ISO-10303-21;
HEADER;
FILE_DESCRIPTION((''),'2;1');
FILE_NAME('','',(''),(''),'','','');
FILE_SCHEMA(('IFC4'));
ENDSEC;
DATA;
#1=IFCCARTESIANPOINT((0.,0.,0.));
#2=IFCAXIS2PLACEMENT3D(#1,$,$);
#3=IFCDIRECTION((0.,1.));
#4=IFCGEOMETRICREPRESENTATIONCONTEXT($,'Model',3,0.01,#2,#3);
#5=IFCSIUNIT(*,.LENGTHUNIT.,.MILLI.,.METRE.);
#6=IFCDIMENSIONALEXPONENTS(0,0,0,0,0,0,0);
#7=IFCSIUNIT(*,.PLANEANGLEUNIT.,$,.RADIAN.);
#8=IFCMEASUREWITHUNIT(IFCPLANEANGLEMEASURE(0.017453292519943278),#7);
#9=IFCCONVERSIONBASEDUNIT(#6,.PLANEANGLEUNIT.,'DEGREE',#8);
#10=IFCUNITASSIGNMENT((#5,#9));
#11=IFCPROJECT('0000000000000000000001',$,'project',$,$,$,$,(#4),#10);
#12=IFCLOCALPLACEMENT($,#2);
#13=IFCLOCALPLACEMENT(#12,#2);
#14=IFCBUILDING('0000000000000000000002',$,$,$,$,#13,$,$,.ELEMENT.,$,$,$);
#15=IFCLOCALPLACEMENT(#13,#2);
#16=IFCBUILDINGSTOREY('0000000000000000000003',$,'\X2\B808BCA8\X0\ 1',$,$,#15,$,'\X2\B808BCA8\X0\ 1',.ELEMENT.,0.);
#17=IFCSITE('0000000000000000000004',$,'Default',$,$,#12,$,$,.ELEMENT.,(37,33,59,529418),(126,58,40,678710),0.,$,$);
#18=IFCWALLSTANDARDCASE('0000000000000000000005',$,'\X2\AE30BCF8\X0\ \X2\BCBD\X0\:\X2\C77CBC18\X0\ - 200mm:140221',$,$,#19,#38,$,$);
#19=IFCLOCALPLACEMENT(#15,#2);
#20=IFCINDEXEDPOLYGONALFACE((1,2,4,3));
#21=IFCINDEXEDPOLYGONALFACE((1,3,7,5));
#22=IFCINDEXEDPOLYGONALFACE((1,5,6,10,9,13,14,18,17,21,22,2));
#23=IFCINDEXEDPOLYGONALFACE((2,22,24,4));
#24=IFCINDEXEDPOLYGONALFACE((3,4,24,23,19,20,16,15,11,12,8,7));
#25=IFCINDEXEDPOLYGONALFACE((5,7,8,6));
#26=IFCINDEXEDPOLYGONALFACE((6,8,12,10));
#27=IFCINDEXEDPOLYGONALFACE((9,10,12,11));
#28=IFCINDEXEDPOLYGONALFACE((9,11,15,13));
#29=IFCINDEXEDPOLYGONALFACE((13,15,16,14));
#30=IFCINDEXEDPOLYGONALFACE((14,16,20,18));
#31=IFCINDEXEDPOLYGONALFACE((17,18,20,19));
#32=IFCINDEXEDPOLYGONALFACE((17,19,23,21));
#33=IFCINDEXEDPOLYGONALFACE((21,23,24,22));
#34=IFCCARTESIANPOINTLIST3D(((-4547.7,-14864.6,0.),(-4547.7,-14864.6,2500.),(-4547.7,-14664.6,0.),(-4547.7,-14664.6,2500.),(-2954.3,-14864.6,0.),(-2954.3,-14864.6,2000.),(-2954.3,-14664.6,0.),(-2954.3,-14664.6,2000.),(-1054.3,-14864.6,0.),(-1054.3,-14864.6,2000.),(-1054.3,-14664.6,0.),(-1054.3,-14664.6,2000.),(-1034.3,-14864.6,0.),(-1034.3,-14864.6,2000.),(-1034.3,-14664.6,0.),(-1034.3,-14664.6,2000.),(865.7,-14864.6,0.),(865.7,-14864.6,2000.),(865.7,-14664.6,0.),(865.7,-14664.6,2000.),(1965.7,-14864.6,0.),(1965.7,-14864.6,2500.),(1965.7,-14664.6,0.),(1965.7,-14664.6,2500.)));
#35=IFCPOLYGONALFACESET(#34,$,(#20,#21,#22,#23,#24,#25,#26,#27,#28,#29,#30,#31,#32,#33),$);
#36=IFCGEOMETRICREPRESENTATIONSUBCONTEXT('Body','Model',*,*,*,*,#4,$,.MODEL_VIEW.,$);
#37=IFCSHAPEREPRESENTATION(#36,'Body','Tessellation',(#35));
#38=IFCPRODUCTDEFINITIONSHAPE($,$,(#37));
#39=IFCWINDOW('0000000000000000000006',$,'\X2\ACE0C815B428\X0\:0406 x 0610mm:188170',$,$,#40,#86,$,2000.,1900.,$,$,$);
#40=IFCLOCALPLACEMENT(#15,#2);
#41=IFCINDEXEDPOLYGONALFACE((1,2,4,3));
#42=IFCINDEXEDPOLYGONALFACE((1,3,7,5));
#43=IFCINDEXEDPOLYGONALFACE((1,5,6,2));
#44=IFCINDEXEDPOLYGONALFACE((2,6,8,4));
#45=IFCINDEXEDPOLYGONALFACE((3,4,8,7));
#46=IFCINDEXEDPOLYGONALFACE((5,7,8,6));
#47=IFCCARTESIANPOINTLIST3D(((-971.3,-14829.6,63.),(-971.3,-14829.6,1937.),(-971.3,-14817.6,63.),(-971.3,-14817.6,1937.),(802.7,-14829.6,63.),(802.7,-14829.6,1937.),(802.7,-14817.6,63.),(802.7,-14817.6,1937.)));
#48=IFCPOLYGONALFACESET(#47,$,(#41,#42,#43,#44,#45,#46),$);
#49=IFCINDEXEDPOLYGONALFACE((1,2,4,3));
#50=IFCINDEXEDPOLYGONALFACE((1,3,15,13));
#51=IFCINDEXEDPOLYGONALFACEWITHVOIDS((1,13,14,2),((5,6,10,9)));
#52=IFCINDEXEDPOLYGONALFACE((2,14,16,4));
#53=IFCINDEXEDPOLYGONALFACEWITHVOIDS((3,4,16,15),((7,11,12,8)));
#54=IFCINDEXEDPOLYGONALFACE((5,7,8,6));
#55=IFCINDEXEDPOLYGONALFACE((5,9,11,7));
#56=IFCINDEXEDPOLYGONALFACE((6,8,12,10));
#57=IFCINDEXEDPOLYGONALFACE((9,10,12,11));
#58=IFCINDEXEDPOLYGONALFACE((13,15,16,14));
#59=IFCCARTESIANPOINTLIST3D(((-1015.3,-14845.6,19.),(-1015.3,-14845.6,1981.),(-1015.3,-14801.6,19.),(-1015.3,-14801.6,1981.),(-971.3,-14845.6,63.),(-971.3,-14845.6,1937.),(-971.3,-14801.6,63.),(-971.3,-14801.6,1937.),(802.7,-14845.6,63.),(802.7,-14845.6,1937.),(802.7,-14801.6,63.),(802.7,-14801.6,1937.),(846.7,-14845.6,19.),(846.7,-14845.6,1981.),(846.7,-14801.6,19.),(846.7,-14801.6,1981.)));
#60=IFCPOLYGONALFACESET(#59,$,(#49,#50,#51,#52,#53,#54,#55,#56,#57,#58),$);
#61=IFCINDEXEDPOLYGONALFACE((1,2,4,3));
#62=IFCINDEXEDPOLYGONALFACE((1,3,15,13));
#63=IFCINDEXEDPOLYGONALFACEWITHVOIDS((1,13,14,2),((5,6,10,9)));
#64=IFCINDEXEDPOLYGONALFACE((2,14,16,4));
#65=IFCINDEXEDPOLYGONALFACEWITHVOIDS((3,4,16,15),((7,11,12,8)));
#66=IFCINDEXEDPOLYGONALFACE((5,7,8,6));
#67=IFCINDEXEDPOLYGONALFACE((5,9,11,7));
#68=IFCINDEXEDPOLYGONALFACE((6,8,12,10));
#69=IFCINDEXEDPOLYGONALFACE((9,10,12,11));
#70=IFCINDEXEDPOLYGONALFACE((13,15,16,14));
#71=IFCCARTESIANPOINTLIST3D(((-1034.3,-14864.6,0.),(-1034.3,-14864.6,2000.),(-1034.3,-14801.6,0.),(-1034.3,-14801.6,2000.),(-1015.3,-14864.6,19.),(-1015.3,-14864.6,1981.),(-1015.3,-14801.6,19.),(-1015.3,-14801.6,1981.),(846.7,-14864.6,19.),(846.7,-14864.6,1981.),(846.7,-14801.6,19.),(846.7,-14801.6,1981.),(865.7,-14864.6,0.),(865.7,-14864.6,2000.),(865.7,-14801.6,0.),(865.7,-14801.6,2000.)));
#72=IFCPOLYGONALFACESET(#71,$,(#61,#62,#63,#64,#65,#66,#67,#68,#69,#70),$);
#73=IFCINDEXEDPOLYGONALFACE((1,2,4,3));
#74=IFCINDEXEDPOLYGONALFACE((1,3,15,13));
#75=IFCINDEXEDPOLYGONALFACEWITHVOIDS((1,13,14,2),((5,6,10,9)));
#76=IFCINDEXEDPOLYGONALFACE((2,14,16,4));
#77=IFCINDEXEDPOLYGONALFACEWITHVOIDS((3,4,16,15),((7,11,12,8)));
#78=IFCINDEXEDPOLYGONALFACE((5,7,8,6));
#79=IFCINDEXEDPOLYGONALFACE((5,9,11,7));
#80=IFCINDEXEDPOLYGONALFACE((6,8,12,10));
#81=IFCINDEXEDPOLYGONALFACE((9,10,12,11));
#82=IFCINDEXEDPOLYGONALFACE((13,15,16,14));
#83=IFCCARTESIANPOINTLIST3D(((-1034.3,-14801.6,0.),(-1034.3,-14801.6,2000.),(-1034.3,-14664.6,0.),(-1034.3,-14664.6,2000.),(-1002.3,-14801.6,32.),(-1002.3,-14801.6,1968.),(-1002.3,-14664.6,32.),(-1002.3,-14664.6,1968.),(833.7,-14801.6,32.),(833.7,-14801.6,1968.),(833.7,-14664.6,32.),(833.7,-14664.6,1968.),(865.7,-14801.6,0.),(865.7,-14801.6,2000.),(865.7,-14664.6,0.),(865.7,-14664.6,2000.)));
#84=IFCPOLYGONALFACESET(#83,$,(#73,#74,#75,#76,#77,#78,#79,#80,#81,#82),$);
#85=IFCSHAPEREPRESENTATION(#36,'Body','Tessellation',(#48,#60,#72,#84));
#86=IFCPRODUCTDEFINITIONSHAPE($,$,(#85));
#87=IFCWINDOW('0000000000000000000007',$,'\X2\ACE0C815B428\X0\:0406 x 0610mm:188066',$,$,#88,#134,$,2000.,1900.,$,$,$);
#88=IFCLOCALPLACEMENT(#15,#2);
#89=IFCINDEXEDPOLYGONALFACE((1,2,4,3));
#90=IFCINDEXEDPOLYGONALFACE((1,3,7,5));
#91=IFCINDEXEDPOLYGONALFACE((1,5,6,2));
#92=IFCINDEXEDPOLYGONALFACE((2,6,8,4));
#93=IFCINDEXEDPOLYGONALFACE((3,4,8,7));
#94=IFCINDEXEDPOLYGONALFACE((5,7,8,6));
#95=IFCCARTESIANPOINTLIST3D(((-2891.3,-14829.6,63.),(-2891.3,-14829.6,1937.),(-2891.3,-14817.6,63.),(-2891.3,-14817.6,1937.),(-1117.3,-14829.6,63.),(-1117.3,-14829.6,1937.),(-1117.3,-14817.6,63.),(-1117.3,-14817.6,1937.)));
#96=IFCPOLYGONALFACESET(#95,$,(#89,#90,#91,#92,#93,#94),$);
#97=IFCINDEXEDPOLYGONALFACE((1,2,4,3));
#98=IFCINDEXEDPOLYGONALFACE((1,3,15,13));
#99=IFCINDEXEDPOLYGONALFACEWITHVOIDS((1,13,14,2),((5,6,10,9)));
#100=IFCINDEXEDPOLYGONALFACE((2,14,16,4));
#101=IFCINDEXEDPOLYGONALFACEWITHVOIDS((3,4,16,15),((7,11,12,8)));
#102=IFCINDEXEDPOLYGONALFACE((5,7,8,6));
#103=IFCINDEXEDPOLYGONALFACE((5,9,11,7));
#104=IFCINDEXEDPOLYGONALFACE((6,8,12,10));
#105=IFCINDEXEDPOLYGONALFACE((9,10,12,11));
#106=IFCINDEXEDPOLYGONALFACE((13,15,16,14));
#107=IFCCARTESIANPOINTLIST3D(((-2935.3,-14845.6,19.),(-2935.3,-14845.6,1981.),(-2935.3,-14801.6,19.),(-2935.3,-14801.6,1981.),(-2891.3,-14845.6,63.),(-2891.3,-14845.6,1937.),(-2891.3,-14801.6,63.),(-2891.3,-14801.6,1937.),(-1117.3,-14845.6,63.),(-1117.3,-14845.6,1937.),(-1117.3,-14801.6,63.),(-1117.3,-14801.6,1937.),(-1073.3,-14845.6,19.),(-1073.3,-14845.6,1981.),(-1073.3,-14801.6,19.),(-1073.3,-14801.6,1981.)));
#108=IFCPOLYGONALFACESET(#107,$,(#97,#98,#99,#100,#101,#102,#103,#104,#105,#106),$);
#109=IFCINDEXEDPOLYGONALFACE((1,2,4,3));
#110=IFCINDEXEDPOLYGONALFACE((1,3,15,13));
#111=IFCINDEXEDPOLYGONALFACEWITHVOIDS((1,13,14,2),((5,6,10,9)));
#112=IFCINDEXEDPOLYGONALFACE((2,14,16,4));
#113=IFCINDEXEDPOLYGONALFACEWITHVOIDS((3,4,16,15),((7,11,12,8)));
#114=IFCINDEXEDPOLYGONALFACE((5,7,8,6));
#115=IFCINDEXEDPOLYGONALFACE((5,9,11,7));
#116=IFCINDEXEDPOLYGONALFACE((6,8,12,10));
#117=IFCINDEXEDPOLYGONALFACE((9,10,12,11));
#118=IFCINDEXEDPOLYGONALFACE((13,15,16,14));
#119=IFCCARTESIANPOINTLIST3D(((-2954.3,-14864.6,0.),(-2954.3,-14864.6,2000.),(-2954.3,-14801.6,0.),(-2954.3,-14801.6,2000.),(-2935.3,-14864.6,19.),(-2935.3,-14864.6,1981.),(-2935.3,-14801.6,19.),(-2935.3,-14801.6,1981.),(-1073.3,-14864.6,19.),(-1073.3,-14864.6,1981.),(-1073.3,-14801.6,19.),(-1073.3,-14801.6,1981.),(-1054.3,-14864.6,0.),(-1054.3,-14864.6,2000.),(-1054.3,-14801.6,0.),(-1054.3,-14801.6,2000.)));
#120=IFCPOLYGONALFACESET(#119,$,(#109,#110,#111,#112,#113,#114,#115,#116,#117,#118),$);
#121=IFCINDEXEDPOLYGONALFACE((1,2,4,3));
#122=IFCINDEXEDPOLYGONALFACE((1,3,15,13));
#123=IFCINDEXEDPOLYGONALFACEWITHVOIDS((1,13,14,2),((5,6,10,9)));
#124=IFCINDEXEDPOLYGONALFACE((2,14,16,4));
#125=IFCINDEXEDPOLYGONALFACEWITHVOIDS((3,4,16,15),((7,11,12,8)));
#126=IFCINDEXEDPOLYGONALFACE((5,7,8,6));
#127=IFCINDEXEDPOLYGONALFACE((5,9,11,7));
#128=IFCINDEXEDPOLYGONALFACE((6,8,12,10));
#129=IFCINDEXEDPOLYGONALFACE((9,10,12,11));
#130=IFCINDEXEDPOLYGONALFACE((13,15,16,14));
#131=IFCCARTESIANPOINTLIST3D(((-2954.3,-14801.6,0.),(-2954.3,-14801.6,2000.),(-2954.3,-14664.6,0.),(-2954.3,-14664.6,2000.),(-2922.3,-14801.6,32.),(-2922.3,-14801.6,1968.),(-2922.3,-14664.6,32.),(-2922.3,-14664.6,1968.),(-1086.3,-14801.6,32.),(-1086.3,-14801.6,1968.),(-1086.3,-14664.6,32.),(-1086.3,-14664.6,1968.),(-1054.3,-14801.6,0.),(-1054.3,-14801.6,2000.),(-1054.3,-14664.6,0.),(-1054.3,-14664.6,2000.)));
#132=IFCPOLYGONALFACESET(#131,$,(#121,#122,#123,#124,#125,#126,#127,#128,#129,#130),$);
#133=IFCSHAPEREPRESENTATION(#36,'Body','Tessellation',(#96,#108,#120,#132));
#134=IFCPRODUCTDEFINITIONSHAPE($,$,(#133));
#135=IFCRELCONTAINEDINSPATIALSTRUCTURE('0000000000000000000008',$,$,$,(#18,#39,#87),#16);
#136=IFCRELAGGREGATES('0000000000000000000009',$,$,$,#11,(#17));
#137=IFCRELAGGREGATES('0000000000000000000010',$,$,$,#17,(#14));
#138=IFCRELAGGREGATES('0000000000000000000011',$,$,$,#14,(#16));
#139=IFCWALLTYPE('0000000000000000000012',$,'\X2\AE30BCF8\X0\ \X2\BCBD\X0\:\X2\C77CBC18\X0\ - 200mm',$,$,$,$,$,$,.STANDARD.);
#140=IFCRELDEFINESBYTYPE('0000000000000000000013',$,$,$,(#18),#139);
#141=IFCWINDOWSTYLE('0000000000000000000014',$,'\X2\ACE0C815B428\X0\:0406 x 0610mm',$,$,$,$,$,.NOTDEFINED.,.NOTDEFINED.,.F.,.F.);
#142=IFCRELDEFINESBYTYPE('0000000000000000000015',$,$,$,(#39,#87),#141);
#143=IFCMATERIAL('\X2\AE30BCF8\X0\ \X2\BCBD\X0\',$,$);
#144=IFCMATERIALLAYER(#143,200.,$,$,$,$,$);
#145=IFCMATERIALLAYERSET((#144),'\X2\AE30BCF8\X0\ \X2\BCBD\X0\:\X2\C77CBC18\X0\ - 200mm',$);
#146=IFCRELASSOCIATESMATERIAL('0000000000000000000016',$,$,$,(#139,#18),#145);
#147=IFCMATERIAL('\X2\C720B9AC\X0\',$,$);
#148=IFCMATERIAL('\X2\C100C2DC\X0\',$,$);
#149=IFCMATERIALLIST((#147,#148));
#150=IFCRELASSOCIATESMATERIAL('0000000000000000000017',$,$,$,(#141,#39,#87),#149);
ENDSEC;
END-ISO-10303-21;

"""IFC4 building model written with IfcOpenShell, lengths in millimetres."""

from ifc_helpers import new_model, entity, si_unit, converted_unit, direction, frame, frame_2d, origin, place, context, subcontext, project, spatial, polyline, rectangle, outline, extrude, source, transform, mapped, material, material_list, layer, layer_set, layer_usage, type_object, type_shapes, element, fill, save


model = new_model("IFC4")

# Units and contexts
model_context = context("Model", 3, precision=0.01, world=origin(), true_north=direction((0.0, 1.0)))
body_context = subcontext(model_context, "Body", "Model", "MODEL_VIEW")
ifc_project = project(units=[si_unit("LENGTHUNIT", "METRE", prefix="MILLI"), converted_unit("PLANEANGLEUNIT", "DEGREE", entity("IfcPlaneAngleMeasure", 0.017453292519943278), si_unit("PLANEANGLEUNIT", "RADIAN"), dimensions=[0, 0, 0, 0, 0, 0, 0])], contexts=[model_context])

# Site, building, storey
site_placement = place(None, origin())
site = spatial("IfcSite", under=ifc_project, at=site_placement, Name="Default", CompositionType="ELEMENT", RefLatitude=(37, 33, 59, 529418), RefLongitude=(126, 58, 40, 678710), RefElevation=0.0)
building_placement = place(site_placement, origin())
building = spatial("IfcBuilding", under=site, at=building_placement, CompositionType="ELEMENT")
storey_placement = place(building_placement, origin())
storey = spatial("IfcBuildingStorey", under=building, at=storey_placement, Name="레벨 1", LongName="레벨 1", CompositionType="ELEMENT", Elevation=0.0)

# Shared definitions
ifc_material_1 = material(Name="기본 벽")
ifc_layer = layer(ifc_material_1, 200.0)
ifc_layer_set = layer_set([ifc_layer], Name="기본 벽:일반 - 200mm")
wall_type = type_object("IfcWallType", Name="기본 벽:일반 - 200mm", PredefinedType="STANDARD", material=ifc_layer_set)
ifc_material_2 = material(Name="유리")
ifc_material_3 = material(Name="섀시")
ifc_material_list_1 = material_list([ifc_material_2, ifc_material_3])

# Wall, openings, windows
ifc_layer_usage_1 = layer_usage(ifc_layer_set, "AXIS2", "NEGATIVE", 100.0)
wall_1_placement = place(storey_placement, frame((1965.7, -14764.6, 0.0), z_axis=(0.0, 0.0, 1.0), x_axis=(-1.0, 0.0, 0.0)))
wall_1 = element("IfcWallStandardCase", 1, at=wall_1_placement, inside=storey, type_object=wall_type, material=ifc_layer_usage_1, Name="기본 벽:일반 - 200mm:140221", context=body_context, shape_type="SweptSolid", body=[
    extrude(rectangle(XDim=6513.5, YDim=200.0, at=frame_2d((3256.7, 0.0), x_axis=(-1.0, 0.0))), origin(), (0.0, 0.0, 1.0), 2500.0),
])
opening_1_placement = place(wall_1_placement, frame((1100.0, -100.0, 0.0)))
opening_1 = element("IfcOpeningElement", 2, at=opening_1_placement, cuts=wall_1, ObjectType="Opening", context=body_context, shape_type="SweptSolid", body=[
    extrude(rectangle(XDim=2000.0, YDim=1900.0, at=frame_2d((1000.0, 950.0), x_axis=(1.0, 0.0))), frame((0.0, 0.0, 0.0), z_axis=(0.0, 1.0, 0.0), x_axis=(0.0, 0.0, 1.0)), (0.0, 0.0, 1.0), 200.0),
])
opening_2_placement = place(wall_1_placement, frame((3020.0, -100.0, 0.0)))
opening_2 = element("IfcOpeningElement", 3, at=opening_2_placement, cuts=wall_1, ObjectType="Opening", context=body_context, shape_type="SweptSolid", body=[
    extrude(rectangle(XDim=2000.0, YDim=1900.0, at=frame_2d((1000.0, 950.0), x_axis=(1.0, 0.0))), frame((0.0, 0.0, 0.0), z_axis=(0.0, 1.0, 0.0), x_axis=(0.0, 0.0, 1.0)), (0.0, 0.0, 1.0), 200.0),
])
window_style_1 = type_object("IfcWindowStyle", Name="고정됨:0406 x 0610mm", ConstructionType="NOTDEFINED", OperationType="NOTDEFINED", ParameterTakesPrecedence=False, Sizeable=False, material=ifc_material_list_1)
shared_shape_1 = source(origin(), body_context, "Body", "SweptSolid", [
    extrude(rectangle(XDim=12.0, YDim=1774.0, at=frame_2d((0.0, 0.0), x_axis=(1.0, 0.0))), frame((950.0, 159.0, 63.0), z_axis=(0.0, 0.0, 1.0), x_axis=(0.0, -1.0, 0.0)), (0.0, 0.0, 1.0), 1874.0),
    extrude(outline(polyline([(-931.0, -981.0), (931.0, -981.0), (931.0, 981.0), (-931.0, 981.0), (-931.0, -981.0)]), holes=[polyline([(-887.0, -937.0), (-887.0, 937.0), (887.0, 937.0), (887.0, -937.0), (-887.0, -937.0)])]), frame((950.0, 137.0, 1000.0), z_axis=(0.0, 1.0, 0.0), x_axis=(1.0, 0.0, 0.0)), (0.0, 0.0, 1.0), 44.0),
    extrude(outline(polyline([(-950.0, -1000.0), (950.0, -1000.0), (950.0, 1000.0), (-950.0, 1000.0), (-950.0, -1000.0)]), holes=[polyline([(-931.0, -981.0), (-931.0, 981.0), (931.0, 981.0), (931.0, -981.0), (-931.0, -981.0)])]), frame((950.0, 137.0, 1000.0), z_axis=(0.0, 1.0, 0.0), x_axis=(1.0, 0.0, 0.0)), (0.0, 0.0, 1.0), 63.0),
    extrude(outline(polyline([(-950.0, -1000.0), (950.0, -1000.0), (950.0, 1000.0), (-950.0, 1000.0), (-950.0, -1000.0)]), holes=[polyline([(-918.0, -968.0), (-918.0, 968.0), (918.0, 968.0), (918.0, -968.0), (-918.0, -968.0)])]), frame((950.0, 0.0, 1000.0), z_axis=(0.0, 1.0, 0.0), x_axis=(1.0, 0.0, 0.0)), (0.0, 0.0, 1.0), 137.0),
])
type_shapes(window_style_1, [shared_shape_1])
window_1_placement = place(opening_1_placement, origin())
window_1 = element("IfcWindow", 4, at=window_1_placement, inside=storey, type_object=window_style_1, material=ifc_material_list_1, Name="고정됨:0406 x 0610mm:188170", OverallHeight=2000.0, OverallWidth=1900.0, context=body_context, shape_type="MappedRepresentation", body=[
    mapped(shared_shape_1, transform((0.0, 0.0, 0.0), scale=1.0)),
])
fill(opening_1, window_1)
window_2_placement = place(opening_2_placement, origin())
window_2 = element("IfcWindow", 5, at=window_2_placement, inside=storey, type_object=window_style_1, material=ifc_material_list_1, Name="고정됨:0406 x 0610mm:188066", OverallHeight=2000.0, OverallWidth=1900.0, context=body_context, shape_type="MappedRepresentation", body=[
    mapped(shared_shape_1, transform((0.0, 0.0, 0.0), scale=1.0)),
])
fill(opening_2, window_2)

save(model, "model.ifc")
